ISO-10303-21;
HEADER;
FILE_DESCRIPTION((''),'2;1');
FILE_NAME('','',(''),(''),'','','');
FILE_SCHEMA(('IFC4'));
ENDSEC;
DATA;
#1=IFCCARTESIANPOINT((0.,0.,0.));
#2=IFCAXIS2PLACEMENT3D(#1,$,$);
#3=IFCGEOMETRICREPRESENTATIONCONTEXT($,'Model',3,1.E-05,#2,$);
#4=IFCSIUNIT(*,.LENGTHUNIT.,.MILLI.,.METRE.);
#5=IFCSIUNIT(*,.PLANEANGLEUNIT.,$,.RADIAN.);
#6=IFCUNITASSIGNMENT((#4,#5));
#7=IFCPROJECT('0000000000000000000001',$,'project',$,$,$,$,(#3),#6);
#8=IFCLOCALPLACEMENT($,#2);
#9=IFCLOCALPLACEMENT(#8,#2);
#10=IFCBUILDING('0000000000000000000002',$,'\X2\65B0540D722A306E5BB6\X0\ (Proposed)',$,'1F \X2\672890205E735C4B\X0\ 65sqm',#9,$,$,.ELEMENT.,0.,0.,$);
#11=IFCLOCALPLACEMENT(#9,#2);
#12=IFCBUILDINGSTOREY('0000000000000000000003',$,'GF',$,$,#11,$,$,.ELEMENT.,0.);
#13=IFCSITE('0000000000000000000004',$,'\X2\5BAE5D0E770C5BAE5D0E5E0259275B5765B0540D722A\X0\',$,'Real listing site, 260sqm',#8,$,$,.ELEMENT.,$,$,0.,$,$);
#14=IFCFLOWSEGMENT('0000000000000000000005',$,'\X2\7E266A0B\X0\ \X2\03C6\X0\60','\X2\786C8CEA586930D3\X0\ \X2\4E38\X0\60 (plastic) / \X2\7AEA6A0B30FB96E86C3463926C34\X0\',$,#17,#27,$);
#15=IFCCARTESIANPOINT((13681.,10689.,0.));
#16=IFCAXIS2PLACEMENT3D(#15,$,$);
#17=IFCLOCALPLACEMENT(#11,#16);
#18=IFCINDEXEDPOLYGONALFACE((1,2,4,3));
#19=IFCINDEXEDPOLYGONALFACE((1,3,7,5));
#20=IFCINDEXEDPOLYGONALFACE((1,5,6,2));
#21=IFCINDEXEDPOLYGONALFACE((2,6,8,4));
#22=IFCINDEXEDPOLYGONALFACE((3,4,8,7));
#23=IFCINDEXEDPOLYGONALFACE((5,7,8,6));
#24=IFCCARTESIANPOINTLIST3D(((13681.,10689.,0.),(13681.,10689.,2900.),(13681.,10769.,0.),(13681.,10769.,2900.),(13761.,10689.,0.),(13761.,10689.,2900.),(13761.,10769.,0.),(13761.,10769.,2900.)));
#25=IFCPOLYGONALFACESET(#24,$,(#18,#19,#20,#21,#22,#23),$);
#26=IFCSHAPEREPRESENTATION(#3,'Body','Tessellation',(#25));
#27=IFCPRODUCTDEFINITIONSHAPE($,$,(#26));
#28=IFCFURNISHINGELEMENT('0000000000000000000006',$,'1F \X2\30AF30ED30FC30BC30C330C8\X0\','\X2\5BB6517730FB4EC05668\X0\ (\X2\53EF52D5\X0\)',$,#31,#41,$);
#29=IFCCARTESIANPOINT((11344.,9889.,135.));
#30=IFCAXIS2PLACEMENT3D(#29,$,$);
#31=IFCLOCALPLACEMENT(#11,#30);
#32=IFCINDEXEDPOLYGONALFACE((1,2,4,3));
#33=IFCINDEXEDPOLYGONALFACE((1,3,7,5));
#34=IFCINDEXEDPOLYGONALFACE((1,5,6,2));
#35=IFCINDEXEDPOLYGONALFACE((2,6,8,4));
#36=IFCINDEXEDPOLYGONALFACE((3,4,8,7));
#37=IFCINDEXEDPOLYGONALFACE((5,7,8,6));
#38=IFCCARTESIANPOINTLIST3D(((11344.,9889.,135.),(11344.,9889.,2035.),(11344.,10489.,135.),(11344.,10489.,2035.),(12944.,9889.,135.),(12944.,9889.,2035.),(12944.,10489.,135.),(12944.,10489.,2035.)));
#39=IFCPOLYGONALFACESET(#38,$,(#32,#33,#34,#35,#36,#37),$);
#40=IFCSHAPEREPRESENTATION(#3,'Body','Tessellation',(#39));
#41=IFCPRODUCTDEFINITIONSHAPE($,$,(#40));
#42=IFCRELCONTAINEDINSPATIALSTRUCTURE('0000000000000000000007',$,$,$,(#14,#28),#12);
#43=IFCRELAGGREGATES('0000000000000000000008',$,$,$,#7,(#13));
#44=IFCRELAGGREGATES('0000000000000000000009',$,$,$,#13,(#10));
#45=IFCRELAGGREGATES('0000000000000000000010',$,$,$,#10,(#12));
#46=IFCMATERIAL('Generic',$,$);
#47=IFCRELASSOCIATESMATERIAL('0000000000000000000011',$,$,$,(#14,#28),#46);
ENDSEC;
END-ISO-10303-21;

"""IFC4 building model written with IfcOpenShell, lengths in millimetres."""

from ifc_helpers import new_model, si_unit, frame, frame_2d, origin, place, context, project, spatial, rectangle, extrude, material, element, save


model = new_model("IFC4")

# Units and contexts
model_context = context("Model", 3, precision=1e-05, world=origin())
ifc_project = project(units=[si_unit("LENGTHUNIT", "METRE", prefix="MILLI"), si_unit("PLANEANGLEUNIT", "RADIAN")], contexts=[model_context])

# Site, building, storey
site_placement = place(None, origin())
site = spatial("IfcSite", under=ifc_project, at=site_placement, Name="宮崎県宮崎市大字新名爪", ObjectType="Real listing site, 260sqm", CompositionType="ELEMENT", RefElevation=0.0)
building_placement = place(site_placement, origin())
building = spatial("IfcBuilding", under=site, at=building_placement, Name="新名爪の家 (Proposed)", ObjectType="1F 木造平屋 65sqm", CompositionType="ELEMENT", ElevationOfRefHeight=0.0, ElevationOfTerrain=0.0)
storey_placement = place(building_placement, origin())
storey = spatial("IfcBuildingStorey", under=building, at=storey_placement, Name="GF", CompositionType="ELEMENT", Elevation=0.0)

# Shared definitions
ifc_material_1 = material(Name="Generic")

# Flow segment
flow_segment_placement = place(storey_placement, frame((13681.0, 10689.0, 0.0)))
element("IfcFlowSegment", 1, at=flow_segment_placement, inside=storey, material=ifc_material_1, Name="縦樋 φ60", Description="硬質塩ビ 丸60 (plastic) / 竪樋・雨水排水", context=model_context, shape_type="SweptSolid", body=[
    extrude(rectangle(XDim=80.0, YDim=80.0, at=frame_2d((40.0, 40.0))), frame((13681.0, 10689.0, 0.0)), (0.0, 0.0, 1.0), 2900.0),
])

# Furnishing element
furnishing_placement = place(storey_placement, frame((11344.0, 9889.0, 135.0)))
element("IfcFurnishingElement", 2, at=furnishing_placement, inside=storey, material=ifc_material_1, Name="1F クローゼット", Description="家具・什器 (可動)", context=model_context, shape_type="SweptSolid", body=[
    extrude(rectangle(XDim=1600.0, YDim=600.0, at=frame_2d((800.0, 300.0))), frame((11344.0, 9889.0, 135.0)), (0.0, 0.0, 1.0), 1900.0),
])

save(model, "model.ifc")
